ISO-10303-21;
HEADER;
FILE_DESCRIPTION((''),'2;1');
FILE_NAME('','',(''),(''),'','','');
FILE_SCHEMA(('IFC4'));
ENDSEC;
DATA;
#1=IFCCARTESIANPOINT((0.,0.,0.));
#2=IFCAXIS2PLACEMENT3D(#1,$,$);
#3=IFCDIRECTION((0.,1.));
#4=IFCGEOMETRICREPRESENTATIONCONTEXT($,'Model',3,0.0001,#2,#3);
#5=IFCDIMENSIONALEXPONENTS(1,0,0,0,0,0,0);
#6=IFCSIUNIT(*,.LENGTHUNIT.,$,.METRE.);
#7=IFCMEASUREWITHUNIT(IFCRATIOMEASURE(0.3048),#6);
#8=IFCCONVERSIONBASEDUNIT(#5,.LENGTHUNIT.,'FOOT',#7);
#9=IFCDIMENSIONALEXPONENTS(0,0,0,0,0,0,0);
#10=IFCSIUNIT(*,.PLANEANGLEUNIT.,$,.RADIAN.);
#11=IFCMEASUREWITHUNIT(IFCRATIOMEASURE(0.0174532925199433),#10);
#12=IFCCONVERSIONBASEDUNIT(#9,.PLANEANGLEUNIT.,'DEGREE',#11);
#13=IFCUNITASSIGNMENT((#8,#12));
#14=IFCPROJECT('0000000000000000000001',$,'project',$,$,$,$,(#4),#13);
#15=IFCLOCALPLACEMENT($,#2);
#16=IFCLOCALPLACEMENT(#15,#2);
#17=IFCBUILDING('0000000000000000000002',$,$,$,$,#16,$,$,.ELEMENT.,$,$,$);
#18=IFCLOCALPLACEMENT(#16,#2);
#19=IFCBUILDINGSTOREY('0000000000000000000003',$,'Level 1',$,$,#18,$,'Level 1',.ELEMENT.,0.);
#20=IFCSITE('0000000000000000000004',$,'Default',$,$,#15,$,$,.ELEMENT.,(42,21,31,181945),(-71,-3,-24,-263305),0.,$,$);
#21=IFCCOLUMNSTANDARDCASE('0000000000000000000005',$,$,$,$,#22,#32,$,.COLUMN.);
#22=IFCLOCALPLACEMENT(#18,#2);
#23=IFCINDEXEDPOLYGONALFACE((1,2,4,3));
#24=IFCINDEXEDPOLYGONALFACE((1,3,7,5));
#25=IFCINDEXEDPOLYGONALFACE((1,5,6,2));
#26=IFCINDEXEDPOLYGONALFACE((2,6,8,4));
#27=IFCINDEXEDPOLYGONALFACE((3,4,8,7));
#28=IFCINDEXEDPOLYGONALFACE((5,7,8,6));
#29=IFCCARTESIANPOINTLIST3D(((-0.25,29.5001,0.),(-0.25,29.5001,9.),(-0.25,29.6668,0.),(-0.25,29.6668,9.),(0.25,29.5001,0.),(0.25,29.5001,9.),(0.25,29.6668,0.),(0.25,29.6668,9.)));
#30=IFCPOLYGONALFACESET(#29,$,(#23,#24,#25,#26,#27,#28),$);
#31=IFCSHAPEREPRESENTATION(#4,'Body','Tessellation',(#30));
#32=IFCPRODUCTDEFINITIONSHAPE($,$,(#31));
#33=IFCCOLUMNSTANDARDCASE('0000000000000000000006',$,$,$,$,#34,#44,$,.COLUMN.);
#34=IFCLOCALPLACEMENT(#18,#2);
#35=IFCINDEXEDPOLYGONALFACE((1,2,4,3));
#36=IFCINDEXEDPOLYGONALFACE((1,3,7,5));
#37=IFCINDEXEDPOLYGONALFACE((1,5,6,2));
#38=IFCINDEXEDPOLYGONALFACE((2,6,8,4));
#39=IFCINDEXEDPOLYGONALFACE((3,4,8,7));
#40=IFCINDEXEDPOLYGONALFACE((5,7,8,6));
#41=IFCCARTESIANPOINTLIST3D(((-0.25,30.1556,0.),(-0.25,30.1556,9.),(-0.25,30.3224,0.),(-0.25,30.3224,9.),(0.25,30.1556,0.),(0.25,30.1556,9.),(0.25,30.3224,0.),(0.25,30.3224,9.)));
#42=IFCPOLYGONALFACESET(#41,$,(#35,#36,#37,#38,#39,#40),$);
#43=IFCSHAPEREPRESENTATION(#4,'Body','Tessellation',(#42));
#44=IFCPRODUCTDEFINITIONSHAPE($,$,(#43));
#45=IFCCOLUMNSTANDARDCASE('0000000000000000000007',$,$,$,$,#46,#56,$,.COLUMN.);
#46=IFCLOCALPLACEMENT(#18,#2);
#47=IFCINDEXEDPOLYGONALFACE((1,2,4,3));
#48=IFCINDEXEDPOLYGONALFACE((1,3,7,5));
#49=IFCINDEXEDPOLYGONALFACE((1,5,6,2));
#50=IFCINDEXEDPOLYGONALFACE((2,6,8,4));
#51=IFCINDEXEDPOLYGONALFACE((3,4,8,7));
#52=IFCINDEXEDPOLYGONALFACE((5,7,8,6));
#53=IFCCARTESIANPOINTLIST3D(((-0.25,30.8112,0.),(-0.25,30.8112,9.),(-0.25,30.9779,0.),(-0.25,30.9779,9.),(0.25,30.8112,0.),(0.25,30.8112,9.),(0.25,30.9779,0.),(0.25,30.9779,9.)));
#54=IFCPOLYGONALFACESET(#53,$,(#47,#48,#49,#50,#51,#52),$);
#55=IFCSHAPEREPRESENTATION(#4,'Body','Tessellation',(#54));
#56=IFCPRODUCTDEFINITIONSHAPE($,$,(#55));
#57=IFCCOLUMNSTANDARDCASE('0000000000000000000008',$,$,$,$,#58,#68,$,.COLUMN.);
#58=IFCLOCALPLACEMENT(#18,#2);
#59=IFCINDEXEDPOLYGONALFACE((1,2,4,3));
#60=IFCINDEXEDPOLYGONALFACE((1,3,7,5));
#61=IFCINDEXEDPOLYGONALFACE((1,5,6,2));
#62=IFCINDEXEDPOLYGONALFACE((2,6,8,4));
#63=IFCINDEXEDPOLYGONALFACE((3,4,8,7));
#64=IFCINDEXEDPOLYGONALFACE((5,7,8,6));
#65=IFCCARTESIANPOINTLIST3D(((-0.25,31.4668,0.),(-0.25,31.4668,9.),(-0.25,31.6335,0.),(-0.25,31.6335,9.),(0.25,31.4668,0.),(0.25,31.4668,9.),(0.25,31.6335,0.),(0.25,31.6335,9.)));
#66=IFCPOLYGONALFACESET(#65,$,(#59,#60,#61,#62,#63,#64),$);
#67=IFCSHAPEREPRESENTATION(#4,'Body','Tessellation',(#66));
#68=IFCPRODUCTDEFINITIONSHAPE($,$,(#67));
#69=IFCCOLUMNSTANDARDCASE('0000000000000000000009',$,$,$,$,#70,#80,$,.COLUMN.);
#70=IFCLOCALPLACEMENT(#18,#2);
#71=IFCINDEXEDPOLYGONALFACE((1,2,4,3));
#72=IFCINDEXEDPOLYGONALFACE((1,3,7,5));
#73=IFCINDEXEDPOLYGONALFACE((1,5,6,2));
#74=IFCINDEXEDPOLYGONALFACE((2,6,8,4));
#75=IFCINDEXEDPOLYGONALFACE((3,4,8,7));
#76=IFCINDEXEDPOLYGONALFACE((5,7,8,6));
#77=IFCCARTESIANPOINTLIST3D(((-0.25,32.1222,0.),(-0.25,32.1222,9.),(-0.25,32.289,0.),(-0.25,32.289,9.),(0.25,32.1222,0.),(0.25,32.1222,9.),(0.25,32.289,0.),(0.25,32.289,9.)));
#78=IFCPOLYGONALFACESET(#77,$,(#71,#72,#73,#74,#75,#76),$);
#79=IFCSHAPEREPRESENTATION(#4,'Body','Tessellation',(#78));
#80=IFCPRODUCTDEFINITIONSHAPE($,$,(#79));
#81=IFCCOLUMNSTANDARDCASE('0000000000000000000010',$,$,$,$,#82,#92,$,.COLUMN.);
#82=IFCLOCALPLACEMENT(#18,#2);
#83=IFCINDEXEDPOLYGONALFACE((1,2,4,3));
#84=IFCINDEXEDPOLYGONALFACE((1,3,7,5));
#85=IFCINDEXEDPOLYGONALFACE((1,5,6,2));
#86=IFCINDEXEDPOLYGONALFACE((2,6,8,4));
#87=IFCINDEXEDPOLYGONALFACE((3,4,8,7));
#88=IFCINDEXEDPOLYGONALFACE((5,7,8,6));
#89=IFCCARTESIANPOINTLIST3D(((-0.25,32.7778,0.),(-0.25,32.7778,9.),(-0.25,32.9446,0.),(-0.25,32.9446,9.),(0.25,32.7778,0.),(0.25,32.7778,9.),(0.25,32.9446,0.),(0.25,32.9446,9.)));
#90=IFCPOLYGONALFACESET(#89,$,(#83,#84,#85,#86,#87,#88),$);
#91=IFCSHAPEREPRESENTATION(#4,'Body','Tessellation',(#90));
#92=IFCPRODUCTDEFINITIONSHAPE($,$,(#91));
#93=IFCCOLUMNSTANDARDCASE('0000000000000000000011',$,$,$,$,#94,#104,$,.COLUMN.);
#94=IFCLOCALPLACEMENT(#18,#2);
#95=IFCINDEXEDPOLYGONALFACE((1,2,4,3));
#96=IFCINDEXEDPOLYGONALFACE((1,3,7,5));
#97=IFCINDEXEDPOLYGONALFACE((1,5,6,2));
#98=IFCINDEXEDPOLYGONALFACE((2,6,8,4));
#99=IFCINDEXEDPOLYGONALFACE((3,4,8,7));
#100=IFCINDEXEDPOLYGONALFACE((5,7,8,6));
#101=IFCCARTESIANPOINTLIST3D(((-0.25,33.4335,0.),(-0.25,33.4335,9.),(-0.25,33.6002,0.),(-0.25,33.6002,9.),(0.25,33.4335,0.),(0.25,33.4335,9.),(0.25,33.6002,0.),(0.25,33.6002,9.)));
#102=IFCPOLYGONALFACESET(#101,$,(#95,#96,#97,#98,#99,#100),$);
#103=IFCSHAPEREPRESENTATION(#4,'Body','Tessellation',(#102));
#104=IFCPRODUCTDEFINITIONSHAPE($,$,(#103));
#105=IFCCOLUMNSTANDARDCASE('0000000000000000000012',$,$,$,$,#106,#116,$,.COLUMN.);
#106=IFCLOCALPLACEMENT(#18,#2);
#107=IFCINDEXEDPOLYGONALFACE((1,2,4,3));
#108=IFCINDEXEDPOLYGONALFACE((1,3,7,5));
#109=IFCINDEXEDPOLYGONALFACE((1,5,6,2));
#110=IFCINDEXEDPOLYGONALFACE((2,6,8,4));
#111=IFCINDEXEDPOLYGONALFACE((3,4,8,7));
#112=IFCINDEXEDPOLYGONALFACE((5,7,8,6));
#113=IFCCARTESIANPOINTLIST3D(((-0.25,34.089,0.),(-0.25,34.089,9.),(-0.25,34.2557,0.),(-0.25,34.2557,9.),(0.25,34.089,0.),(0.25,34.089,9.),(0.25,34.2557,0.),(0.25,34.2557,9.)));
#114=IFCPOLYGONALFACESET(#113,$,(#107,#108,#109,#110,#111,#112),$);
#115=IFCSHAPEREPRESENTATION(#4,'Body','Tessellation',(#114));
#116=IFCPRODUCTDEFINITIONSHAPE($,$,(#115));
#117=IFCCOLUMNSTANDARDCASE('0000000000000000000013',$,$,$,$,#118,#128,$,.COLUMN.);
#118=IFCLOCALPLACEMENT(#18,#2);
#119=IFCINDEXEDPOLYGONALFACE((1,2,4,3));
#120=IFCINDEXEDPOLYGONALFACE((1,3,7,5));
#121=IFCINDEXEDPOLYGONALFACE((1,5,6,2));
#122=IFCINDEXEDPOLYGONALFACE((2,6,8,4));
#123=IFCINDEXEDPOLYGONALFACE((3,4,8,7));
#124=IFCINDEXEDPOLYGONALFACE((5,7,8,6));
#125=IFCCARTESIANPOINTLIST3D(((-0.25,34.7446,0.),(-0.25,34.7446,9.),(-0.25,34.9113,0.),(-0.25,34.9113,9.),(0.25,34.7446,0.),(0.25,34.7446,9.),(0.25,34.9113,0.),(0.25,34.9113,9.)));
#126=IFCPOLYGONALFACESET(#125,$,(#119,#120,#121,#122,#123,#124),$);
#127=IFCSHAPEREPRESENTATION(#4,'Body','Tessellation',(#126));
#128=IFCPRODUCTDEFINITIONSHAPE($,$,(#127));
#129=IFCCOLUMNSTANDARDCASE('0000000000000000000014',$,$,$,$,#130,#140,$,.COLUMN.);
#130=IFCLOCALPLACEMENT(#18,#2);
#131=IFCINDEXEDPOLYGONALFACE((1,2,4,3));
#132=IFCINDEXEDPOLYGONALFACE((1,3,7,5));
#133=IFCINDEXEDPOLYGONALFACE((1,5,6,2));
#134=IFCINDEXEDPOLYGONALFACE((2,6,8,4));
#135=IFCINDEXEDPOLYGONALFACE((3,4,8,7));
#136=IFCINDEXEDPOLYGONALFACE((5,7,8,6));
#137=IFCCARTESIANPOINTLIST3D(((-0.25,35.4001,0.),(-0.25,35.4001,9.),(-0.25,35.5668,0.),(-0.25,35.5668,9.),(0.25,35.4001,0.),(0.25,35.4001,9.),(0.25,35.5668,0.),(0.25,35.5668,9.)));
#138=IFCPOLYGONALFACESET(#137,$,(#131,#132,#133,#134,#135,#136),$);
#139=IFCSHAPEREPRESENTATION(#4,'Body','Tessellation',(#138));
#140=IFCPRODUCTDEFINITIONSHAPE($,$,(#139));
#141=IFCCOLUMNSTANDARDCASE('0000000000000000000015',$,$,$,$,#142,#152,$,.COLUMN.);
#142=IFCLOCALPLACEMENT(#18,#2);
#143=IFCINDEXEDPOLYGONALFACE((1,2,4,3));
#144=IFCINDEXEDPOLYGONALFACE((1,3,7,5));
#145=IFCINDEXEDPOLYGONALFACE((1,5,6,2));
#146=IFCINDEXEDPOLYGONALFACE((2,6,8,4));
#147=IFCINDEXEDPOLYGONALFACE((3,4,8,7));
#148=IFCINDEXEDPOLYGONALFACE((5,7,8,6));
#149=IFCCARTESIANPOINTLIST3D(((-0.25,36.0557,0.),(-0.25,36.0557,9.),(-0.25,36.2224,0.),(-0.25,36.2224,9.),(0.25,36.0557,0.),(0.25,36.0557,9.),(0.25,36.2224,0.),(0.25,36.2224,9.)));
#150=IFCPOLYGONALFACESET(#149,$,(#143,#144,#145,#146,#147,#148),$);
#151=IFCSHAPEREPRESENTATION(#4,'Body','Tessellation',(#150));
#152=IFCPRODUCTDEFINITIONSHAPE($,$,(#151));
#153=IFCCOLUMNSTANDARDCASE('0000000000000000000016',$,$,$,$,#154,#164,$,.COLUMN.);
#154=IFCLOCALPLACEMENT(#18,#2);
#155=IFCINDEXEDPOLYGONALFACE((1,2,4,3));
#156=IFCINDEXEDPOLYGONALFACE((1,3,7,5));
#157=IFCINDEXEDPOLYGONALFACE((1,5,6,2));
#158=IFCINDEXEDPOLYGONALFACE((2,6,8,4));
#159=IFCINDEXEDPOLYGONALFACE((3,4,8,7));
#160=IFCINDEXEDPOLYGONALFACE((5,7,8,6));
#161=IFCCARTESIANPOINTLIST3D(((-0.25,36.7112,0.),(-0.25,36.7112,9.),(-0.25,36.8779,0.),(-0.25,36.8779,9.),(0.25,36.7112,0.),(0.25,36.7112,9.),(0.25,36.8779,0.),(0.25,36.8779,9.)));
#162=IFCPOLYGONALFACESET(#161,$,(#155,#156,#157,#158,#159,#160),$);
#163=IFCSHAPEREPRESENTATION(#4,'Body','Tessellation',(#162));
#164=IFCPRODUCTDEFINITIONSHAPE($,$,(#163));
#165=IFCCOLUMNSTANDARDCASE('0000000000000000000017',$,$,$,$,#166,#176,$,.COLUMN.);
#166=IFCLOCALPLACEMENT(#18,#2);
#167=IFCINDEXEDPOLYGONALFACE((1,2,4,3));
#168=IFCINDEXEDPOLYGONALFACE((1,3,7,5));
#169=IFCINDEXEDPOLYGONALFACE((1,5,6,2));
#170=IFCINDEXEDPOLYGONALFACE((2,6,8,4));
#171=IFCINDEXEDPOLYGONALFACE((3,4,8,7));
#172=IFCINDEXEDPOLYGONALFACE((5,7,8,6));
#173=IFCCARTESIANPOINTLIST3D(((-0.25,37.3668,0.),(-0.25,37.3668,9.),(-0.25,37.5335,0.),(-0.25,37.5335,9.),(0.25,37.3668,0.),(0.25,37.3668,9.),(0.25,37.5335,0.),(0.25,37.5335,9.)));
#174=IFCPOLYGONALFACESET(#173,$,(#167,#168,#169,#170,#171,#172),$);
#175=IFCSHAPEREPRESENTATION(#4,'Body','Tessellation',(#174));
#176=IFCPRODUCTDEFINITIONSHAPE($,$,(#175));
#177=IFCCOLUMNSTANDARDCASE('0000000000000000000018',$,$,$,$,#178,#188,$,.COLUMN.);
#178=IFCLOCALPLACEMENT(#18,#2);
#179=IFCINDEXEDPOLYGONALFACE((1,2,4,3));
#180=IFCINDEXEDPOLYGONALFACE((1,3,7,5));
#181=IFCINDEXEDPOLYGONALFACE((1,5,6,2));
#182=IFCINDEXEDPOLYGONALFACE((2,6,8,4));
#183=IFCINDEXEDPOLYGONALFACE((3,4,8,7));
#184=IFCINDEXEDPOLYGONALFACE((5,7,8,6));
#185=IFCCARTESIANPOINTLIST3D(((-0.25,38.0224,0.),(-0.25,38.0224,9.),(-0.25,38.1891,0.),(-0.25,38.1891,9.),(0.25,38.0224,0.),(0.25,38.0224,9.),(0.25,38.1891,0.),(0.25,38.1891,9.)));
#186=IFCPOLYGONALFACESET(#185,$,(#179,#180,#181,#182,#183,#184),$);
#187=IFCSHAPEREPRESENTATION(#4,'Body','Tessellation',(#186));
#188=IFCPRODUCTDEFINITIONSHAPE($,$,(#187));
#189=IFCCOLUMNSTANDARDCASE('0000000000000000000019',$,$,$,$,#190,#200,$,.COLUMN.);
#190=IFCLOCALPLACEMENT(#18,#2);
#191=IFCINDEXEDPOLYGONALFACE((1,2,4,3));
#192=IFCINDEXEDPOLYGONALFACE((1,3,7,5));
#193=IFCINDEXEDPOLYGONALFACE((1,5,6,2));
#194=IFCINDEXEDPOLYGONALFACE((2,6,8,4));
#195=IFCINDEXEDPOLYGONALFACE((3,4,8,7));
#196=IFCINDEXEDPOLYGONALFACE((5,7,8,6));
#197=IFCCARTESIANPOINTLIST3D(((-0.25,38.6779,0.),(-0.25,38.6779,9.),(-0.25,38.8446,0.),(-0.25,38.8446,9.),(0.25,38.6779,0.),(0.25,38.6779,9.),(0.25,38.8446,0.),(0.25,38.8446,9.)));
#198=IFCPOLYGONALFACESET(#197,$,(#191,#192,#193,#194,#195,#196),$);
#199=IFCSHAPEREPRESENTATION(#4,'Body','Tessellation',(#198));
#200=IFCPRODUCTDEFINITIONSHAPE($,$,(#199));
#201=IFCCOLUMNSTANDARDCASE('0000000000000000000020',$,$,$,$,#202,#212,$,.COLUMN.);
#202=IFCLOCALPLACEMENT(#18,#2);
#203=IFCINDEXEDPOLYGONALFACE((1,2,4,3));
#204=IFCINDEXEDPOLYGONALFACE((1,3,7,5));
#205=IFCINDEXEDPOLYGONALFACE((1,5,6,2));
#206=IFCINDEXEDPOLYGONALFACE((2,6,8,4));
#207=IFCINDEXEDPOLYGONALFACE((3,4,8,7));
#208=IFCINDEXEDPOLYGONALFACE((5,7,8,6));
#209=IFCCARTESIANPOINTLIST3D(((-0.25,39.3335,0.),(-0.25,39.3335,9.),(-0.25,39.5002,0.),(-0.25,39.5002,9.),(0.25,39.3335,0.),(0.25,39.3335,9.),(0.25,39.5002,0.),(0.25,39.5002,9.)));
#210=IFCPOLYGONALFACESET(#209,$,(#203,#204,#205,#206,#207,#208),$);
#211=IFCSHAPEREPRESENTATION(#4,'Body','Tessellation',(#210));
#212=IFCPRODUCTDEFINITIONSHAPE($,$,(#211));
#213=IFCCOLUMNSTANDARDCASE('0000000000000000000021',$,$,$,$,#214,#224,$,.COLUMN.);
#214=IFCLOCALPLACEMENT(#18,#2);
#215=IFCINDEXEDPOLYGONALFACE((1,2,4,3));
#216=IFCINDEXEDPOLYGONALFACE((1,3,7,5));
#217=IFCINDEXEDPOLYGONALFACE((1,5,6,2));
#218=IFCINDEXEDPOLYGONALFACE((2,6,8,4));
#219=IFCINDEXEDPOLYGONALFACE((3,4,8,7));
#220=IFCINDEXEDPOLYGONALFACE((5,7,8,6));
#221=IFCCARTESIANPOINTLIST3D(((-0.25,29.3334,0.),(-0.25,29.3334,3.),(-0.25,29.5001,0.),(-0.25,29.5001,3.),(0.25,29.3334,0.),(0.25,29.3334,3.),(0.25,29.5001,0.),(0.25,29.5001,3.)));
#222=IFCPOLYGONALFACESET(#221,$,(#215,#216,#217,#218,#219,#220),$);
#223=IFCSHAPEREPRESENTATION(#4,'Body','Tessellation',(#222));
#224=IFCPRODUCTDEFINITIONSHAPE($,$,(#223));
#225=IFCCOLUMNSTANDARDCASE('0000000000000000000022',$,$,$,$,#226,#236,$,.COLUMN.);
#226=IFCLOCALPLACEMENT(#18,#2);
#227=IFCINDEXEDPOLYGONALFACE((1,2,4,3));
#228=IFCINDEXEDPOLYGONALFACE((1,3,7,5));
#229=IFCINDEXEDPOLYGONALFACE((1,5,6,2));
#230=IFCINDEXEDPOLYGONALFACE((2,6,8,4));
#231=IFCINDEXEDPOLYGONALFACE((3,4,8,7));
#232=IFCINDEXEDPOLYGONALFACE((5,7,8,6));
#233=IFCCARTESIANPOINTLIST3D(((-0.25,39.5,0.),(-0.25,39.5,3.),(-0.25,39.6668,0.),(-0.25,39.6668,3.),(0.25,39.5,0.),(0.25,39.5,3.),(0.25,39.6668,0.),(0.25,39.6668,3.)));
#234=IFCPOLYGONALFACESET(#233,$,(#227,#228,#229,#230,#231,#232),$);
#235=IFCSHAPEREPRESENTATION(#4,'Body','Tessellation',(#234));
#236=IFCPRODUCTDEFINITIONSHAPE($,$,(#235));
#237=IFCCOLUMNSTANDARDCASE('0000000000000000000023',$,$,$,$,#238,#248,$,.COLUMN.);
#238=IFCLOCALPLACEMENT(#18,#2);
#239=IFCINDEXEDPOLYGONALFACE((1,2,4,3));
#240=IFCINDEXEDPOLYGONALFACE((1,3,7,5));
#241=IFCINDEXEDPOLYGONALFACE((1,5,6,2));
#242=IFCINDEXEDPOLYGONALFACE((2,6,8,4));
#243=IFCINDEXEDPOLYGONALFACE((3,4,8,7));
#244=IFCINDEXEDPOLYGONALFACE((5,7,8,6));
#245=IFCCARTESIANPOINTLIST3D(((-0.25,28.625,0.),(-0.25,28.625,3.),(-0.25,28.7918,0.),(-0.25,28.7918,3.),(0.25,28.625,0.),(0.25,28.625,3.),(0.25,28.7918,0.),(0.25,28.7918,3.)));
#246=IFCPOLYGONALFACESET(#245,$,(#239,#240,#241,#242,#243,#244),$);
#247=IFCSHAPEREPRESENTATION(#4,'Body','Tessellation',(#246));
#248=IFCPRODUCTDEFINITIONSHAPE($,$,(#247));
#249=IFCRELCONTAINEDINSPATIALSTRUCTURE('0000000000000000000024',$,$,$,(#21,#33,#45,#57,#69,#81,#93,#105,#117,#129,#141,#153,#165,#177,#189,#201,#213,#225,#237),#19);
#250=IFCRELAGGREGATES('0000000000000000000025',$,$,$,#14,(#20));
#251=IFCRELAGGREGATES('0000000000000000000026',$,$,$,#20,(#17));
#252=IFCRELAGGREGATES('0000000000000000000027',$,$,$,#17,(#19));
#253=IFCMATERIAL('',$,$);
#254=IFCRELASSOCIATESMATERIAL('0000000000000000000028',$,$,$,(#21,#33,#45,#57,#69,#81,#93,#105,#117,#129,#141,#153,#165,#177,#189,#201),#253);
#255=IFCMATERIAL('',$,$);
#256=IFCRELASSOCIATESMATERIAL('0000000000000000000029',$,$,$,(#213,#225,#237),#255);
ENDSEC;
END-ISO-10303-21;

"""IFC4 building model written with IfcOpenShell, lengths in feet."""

from ifc_helpers import new_model, entity, si_unit, converted_unit, direction, frame, origin, place, context, project, spatial, rectangle, extrude, material, element, save


model = new_model("IFC4")

# Units and contexts
model_context = context("Model", 3, precision=0.0001, world=origin(), true_north=direction((0.0, 1.0)))
ifc_project = project(units=[converted_unit("LENGTHUNIT", "FOOT", entity("IfcRatioMeasure", 0.3048), si_unit("LENGTHUNIT", "METRE"), dimensions=[1, 0, 0, 0, 0, 0, 0]), converted_unit("PLANEANGLEUNIT", "DEGREE", entity("IfcRatioMeasure", 0.0174532925199433), si_unit("PLANEANGLEUNIT", "RADIAN"), dimensions=[0, 0, 0, 0, 0, 0, 0])], contexts=[model_context])

# Site, building, storey
site_placement = place(None, origin())
site = spatial("IfcSite", under=ifc_project, at=site_placement, Name="Default", CompositionType="ELEMENT", RefLatitude=(42, 21, 31, 181945), RefLongitude=(-71, -3, -24, -263305), RefElevation=0.0)
building_placement = place(site_placement, origin())
building = spatial("IfcBuilding", under=site, at=building_placement, CompositionType="ELEMENT")
storey_placement = place(building_placement, origin())
storey = spatial("IfcBuildingStorey", under=building, at=storey_placement, Name="Level 1", LongName="Level 1", CompositionType="ELEMENT", Elevation=0.0)

# Columns
ifc_material_1 = material(Name="")
placement_1 = place(storey_placement, frame((0.0, -0.25, 0.0), z_axis=(0.0, 0.0, 1.0), x_axis=(0.0, 1.0, 0.0)))
for number, where, z_axis, x_axis in (
    (1, (29.8334, 0.0, 0.0), (0.0, 0.0, 1.0), (1.0, 0.0, 0.0)),
    (2, (30.489, 0.0, 0.0), (0.0, 0.0, 1.0), (1.0, 0.0, 0.0)),
    (3, (31.1445, 0.0, 0.0), (0.0, 0.0, 1.0), (1.0, 0.0, 0.0)),
    (4, (31.8001, 0.0, 0.0), (0.0, 0.0, 1.0), (1.0, 0.0, 0.0)),
    (5, (32.4556, 0.0, 0.0), (0.0, 0.0, 1.0), (1.0, 0.0, 0.0)),
    (6, (33.1112, 0.0, 0.0), (0.0, 0.0, 1.0), (1.0, 0.0, 0.0)),
    (7, (33.7668, 0.0, 0.0), (0.0, 0.0, 1.0), (1.0, 0.0, 0.0)),
    (8, (34.4223, 0.0, 0.0), (0.0, 0.0, 1.0), (1.0, 0.0, 0.0)),
    (9, (35.0779, 0.0, 0.0), (0.0, 0.0, 1.0), (1.0, 0.0, 0.0)),
    (10, (35.7334, 0.0, 0.0), (0.0, 0.0, 1.0), (1.0, 0.0, 0.0)),
    (11, (36.389, 0.0, 0.0), (0.0, 0.0, 1.0), (1.0, 0.0, 0.0)),
    (12, (37.0445, 0.0, 0.0), (0.0, 0.0, 1.0), (1.0, 0.0, 0.0)),
    (13, (37.7001, 0.0, 0.0), (0.0, 0.0, 1.0), (1.0, 0.0, 0.0)),
    (14, (38.3557, 0.0, 0.0), (0.0, 0.0, 1.0), (1.0, 0.0, 0.0)),
    (15, (39.0112, 0.0, 0.0), (0.0, 0.0, 1.0), (1.0, 0.0, 0.0)),
    (16, (39.6668, 0.0, 0.0), (0.0, 0.0, 1.0), (1.0, 0.0, 0.0)),
):
    element("IfcColumnStandardCase", number, at=place(placement_1, frame(where, z_axis=z_axis, x_axis=x_axis)), inside=storey, material=ifc_material_1, PredefinedType="COLUMN", context=model_context, shape_type="SweptSolid", body=[
        extrude(rectangle(XDim=0.1667, YDim=0.5), origin(), (0.0, 0.0, 1.0), 9.0),
    ])
ifc_material_2 = material(Name="")
for number, where, z_axis, x_axis in (
    (17, (29.6667, 0.0, 0.0), (0.0, 0.0, 1.0), (1.0, 0.0, 0.0)),
    (18, (39.8334, 0.0, 0.0), (0.0, 0.0, 1.0), (1.0, 0.0, 0.0)),
    (19, (28.9584, 0.0, 0.0), (0.0, 0.0, 1.0), (1.0, 0.0, 0.0)),
):
    element("IfcColumnStandardCase", number, at=place(placement_1, frame(where, z_axis=z_axis, x_axis=x_axis)), inside=storey, material=ifc_material_2, PredefinedType="COLUMN", context=model_context, shape_type="SweptSolid", body=[
        extrude(rectangle(XDim=0.1667, YDim=0.5), origin(), (0.0, 0.0, 1.0), 3.0),
    ])

save(model, "model.ifc")
